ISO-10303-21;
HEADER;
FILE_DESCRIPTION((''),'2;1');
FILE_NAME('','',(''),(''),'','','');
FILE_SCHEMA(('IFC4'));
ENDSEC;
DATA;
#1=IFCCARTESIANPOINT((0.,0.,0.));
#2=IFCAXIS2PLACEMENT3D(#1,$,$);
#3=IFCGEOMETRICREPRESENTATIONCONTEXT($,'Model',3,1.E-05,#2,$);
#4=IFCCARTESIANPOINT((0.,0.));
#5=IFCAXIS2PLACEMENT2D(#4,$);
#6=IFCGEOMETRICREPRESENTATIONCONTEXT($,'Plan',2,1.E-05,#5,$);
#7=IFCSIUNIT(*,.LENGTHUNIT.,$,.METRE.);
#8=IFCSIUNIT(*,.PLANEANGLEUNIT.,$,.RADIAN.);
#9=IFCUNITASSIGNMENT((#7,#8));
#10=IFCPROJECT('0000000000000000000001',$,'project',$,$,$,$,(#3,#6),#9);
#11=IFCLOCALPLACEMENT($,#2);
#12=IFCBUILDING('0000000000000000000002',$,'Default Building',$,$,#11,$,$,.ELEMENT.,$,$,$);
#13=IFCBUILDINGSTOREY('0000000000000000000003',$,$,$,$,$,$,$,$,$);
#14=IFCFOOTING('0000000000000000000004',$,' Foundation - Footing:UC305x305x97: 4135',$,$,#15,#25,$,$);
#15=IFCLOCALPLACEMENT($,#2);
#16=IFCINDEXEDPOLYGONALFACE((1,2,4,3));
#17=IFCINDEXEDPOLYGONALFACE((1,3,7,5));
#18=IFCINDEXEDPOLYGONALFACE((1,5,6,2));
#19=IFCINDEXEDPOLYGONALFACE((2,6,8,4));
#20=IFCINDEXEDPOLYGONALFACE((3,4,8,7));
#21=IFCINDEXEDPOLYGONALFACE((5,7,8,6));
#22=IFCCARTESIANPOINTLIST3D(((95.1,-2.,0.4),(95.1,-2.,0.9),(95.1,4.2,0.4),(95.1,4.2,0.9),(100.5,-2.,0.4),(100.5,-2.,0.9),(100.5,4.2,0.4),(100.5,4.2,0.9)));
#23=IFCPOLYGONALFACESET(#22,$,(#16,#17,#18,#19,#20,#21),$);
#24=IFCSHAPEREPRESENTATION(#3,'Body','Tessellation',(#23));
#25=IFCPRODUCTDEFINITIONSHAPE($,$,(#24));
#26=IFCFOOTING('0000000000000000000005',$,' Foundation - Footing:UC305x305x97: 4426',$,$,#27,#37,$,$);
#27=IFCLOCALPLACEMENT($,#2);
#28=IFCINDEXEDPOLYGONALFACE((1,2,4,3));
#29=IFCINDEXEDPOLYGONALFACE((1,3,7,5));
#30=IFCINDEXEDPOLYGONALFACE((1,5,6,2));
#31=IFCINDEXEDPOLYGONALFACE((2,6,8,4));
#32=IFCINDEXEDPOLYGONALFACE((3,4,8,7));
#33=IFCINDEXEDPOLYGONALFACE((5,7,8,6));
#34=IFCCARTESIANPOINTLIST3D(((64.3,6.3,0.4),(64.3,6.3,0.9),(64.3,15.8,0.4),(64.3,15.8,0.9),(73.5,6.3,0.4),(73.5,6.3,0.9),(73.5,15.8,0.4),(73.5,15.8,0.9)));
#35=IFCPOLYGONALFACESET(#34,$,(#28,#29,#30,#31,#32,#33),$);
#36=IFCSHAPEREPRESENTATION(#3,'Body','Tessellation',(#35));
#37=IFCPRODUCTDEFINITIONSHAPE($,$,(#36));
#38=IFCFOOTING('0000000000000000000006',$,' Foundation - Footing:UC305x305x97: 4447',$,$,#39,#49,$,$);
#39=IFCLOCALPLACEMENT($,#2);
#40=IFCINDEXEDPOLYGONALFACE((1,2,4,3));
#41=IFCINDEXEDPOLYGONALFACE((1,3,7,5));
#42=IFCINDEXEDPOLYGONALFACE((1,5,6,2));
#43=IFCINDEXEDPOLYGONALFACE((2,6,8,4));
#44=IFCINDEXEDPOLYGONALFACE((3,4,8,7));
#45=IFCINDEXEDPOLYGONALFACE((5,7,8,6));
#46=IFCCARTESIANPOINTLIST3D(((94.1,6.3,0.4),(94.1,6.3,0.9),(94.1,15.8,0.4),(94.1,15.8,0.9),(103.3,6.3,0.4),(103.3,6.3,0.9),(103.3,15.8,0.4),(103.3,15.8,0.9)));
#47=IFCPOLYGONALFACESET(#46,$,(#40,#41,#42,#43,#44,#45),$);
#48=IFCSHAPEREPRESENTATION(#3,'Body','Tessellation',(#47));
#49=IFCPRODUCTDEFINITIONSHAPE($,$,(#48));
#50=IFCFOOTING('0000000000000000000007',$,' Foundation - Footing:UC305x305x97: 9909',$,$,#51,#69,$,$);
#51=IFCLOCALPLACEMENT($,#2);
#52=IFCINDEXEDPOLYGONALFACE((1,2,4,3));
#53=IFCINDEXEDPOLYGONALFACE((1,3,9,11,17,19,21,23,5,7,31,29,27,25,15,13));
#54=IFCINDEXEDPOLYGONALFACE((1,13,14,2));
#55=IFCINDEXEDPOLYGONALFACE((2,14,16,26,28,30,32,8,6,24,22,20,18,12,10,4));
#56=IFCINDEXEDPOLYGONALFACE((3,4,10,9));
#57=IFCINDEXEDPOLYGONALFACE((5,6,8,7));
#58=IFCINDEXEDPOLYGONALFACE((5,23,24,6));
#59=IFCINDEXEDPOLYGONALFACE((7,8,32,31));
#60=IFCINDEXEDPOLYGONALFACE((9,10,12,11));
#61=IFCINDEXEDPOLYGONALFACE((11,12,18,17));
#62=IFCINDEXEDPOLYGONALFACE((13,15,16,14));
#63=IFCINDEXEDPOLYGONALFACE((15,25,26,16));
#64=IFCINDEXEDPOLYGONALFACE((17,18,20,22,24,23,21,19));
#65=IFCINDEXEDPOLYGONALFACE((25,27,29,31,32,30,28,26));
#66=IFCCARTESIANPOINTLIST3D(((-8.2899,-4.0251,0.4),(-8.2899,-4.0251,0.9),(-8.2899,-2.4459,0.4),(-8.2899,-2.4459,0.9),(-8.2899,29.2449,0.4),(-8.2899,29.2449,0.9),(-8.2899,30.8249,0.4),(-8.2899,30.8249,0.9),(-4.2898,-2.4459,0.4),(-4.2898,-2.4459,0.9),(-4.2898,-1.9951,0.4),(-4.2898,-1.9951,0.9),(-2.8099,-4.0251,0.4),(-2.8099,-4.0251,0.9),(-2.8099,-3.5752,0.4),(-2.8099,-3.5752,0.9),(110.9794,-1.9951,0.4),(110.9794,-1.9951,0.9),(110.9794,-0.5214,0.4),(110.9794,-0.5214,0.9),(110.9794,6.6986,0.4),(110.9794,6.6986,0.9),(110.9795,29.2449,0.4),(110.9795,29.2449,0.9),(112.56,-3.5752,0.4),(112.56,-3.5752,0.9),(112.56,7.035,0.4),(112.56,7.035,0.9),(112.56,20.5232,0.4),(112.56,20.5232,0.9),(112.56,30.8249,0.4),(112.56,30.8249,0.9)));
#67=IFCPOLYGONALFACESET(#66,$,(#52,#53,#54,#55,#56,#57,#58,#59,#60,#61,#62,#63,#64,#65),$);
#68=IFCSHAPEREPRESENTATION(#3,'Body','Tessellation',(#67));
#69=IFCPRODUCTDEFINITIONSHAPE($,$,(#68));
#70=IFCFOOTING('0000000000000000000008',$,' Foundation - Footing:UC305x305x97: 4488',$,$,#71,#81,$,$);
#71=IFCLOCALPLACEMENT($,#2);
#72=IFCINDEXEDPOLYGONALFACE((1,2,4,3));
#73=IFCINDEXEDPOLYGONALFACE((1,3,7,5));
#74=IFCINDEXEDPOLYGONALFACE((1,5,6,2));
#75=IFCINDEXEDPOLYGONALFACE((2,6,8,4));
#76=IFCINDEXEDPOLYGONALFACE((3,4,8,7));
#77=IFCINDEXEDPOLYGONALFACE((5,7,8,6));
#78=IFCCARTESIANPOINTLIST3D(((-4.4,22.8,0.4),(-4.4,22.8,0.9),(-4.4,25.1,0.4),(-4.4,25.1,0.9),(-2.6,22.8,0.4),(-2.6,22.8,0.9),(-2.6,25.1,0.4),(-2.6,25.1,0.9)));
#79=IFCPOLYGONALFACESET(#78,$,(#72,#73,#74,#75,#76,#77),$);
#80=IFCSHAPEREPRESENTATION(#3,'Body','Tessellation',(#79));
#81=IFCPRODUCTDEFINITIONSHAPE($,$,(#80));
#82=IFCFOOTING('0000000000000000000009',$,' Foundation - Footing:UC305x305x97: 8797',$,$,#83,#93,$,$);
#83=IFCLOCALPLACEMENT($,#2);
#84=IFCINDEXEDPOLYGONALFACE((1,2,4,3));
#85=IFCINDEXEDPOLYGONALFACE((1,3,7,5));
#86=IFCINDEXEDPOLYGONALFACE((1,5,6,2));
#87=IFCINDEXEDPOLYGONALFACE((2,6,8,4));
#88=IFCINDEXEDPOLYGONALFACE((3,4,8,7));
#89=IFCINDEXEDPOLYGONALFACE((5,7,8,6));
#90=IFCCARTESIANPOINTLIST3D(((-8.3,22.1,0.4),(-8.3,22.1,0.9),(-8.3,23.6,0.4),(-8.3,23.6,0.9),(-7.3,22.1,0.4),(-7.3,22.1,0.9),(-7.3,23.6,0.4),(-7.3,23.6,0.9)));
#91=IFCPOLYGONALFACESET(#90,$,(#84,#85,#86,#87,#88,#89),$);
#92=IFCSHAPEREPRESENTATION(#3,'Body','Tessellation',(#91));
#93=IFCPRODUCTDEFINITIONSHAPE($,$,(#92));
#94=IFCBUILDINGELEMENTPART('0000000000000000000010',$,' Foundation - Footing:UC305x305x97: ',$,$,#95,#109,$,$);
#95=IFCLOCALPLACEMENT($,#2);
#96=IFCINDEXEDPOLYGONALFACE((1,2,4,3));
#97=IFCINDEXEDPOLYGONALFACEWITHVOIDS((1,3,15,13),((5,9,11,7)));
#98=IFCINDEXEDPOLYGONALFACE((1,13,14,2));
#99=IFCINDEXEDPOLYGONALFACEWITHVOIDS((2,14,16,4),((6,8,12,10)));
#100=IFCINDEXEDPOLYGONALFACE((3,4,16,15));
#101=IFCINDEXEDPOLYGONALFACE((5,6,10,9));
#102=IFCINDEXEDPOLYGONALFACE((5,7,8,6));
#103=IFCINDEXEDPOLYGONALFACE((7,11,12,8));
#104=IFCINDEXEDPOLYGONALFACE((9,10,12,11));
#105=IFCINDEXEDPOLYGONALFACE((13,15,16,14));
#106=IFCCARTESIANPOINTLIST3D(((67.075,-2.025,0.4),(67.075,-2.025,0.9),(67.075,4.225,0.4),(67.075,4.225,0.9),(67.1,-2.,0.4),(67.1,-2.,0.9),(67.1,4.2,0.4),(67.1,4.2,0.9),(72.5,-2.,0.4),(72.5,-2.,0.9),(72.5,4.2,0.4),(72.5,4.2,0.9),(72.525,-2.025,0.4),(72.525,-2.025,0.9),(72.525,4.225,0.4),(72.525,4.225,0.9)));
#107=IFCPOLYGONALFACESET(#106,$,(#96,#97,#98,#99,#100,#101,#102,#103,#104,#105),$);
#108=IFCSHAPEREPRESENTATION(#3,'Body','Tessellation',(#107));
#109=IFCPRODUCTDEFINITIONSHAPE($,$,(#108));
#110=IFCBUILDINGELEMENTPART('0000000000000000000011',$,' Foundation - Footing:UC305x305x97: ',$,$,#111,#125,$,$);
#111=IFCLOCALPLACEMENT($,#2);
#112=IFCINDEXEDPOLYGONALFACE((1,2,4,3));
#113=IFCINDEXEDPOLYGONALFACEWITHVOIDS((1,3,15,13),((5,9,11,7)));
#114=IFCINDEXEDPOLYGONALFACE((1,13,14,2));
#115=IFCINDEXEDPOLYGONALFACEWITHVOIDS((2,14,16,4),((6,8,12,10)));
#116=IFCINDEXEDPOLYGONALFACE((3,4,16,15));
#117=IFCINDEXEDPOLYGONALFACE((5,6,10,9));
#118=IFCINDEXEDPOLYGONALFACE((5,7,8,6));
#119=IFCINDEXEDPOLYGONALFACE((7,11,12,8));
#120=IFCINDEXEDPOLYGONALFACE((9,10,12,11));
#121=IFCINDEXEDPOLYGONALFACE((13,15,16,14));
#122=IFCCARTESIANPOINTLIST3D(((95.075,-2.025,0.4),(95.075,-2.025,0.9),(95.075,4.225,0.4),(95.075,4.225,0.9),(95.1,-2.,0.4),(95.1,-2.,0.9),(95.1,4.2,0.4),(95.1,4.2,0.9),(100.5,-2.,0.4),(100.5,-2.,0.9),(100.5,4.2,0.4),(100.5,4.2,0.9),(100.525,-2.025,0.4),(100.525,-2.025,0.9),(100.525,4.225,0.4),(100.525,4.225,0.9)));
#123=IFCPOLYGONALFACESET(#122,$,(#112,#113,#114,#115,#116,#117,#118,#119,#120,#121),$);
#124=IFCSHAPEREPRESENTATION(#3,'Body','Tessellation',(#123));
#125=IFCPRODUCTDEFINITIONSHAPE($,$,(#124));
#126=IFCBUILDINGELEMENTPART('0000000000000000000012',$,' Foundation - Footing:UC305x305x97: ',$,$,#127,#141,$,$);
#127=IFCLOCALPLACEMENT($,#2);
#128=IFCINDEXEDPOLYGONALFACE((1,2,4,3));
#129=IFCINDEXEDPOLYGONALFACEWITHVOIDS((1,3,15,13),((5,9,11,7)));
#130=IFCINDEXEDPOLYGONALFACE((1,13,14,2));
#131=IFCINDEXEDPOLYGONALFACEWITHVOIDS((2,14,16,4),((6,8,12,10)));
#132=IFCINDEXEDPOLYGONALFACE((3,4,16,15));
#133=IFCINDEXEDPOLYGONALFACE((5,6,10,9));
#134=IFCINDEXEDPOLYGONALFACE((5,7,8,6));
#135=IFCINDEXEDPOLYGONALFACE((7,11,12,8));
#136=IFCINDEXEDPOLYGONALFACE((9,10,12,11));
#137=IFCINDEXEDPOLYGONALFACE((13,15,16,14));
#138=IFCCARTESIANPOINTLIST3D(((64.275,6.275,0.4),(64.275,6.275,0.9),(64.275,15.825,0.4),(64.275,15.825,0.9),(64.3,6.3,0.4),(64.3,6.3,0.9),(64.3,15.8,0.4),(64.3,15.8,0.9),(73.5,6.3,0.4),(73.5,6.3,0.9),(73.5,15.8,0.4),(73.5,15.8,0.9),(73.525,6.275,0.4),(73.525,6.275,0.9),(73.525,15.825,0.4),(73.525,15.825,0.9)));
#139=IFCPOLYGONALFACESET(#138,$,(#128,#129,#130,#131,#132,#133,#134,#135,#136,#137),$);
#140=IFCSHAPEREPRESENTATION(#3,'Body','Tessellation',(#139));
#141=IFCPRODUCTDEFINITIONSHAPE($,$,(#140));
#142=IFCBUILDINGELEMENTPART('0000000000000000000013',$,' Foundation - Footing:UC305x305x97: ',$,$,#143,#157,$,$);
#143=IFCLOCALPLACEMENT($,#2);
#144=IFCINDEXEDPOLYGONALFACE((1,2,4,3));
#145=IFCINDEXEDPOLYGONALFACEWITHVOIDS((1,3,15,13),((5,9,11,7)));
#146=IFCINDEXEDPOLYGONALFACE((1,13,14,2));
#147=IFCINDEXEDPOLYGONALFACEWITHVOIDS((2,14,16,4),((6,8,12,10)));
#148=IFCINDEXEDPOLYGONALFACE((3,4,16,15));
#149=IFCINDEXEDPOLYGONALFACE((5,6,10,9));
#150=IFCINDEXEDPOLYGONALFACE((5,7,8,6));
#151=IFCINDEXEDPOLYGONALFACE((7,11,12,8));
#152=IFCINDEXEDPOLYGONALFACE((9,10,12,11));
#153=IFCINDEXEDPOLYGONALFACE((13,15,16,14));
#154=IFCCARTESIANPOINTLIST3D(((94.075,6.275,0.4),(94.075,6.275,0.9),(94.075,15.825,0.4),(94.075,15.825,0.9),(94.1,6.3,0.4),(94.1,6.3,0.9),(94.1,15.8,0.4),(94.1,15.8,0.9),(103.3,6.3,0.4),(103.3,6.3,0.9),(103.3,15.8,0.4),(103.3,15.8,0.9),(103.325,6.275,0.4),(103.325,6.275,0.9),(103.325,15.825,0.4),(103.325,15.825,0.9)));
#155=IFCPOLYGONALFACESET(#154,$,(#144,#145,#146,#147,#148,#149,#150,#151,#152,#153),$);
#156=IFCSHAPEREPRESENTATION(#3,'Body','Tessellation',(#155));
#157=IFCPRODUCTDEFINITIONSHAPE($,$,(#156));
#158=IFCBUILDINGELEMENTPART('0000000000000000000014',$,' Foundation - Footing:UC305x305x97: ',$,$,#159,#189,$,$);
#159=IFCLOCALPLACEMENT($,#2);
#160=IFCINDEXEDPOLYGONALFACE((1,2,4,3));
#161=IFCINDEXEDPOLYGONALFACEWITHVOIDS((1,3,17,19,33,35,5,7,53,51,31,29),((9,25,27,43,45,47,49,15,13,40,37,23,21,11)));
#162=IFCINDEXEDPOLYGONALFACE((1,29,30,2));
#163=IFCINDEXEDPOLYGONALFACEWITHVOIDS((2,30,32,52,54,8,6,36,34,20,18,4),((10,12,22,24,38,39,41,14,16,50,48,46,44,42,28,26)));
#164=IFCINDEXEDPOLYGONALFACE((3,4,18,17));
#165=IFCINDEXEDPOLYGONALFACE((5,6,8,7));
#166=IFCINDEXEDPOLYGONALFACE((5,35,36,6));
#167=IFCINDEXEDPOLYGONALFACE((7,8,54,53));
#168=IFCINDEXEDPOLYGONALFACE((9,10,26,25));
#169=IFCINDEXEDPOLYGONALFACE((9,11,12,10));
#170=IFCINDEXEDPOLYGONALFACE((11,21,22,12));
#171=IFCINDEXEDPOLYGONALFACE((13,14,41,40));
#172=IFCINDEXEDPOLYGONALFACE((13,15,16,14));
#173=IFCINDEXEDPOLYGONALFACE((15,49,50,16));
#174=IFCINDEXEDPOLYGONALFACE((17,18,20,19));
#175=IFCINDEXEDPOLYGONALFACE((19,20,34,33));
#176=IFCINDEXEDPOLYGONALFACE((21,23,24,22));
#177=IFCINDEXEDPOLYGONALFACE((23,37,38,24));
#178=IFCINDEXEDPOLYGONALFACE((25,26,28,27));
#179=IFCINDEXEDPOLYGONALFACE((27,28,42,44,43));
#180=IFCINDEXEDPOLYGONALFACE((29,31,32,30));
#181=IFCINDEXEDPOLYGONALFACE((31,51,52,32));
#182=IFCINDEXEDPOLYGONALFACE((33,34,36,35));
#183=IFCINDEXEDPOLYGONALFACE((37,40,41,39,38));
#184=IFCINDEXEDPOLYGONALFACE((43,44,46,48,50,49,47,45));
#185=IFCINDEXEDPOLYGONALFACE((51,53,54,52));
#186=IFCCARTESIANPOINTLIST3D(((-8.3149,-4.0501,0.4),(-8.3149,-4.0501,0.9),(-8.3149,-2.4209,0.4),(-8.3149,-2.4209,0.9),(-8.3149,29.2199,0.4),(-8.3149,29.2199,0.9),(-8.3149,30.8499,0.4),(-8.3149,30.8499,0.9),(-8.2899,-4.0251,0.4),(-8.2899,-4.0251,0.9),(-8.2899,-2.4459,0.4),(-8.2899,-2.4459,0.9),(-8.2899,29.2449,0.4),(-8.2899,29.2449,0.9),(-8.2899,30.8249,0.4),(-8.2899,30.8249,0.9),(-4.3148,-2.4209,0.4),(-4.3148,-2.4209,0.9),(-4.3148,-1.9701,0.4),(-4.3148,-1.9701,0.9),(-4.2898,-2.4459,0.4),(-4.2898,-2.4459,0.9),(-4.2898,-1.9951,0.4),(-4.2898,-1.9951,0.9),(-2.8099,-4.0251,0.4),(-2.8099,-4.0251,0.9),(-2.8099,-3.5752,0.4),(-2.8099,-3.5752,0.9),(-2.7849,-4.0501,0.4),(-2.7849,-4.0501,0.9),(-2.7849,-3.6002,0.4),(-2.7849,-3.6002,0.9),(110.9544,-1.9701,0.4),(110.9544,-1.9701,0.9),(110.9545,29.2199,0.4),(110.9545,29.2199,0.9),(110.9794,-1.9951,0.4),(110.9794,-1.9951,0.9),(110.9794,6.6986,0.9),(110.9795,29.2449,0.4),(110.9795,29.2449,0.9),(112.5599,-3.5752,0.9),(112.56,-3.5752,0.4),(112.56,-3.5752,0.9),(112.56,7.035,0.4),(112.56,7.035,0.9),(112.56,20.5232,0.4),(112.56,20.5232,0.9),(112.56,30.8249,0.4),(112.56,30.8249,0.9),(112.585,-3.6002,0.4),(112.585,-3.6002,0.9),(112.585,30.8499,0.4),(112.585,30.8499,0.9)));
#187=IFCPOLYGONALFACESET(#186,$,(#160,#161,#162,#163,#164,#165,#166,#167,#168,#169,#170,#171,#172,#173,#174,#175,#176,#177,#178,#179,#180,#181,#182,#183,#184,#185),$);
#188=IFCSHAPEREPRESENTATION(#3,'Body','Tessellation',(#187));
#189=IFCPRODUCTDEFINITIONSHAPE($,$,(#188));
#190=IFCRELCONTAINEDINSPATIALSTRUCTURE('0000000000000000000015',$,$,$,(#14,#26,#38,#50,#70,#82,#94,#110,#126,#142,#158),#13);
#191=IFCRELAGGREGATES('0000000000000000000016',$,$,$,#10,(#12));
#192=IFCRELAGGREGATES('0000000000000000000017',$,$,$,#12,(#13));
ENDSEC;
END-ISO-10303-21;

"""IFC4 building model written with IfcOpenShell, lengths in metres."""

from ifc_helpers import new_model, si_unit, origin, origin_2d, place, context, project, spatial, polyline, outline, extrude, element, save


model = new_model("IFC4")

# Units and contexts
model_context = context("Model", 3, precision=1e-05, world=origin())
plan_context = context("Plan", 2, precision=1e-05, world=origin_2d())
ifc_project = project(units=[si_unit("LENGTHUNIT", "METRE"), si_unit("PLANEANGLEUNIT", "RADIAN")], contexts=[model_context, plan_context])

# Building, storey
building_placement = place(None, origin())
building = spatial("IfcBuilding", under=ifc_project, at=building_placement, Name="Default Building", CompositionType="ELEMENT")
storey = spatial("IfcBuildingStorey", under=building)

# Footings
element("IfcFooting", 1, inside=storey, Name=" Foundation - Footing:UC305x305x97: 4135", context=model_context, shape_type="SweptSolid", body=[
    extrude(outline(polyline([(100.5, -2.0, 0.4), (100.5, 4.2, 0.4), (95.1, 4.2, 0.4), (95.1, -2.0, 0.4), (100.5, -2.0, 0.4)])), None, (0.0, 0.0, 1.0), 0.5),
])
element("IfcFooting", 2, inside=storey, Name=" Foundation - Footing:UC305x305x97: 4426", context=model_context, shape_type="SweptSolid", body=[
    extrude(outline(polyline([(64.3, 15.8, 0.4), (73.5, 15.8, 0.4), (73.5, 6.3, 0.4), (64.3, 6.3, 0.4), (64.3, 15.8, 0.4)])), None, (0.0, 0.0, 1.0), 0.5),
])
element("IfcFooting", 3, inside=storey, Name=" Foundation - Footing:UC305x305x97: 4447", context=model_context, shape_type="SweptSolid", body=[
    extrude(outline(polyline([(94.1, 15.8, 0.4), (103.3, 15.8, 0.4), (103.3, 6.3, 0.4), (94.1, 6.3, 0.4), (94.1, 15.8, 0.4)])), None, (0.0, 0.0, 1.0), 0.5),
])
element("IfcFooting", 4, inside=storey, Name=" Foundation - Footing:UC305x305x97: 9909", context=model_context, shape_type="SweptSolid", body=[
    extrude(outline(polyline([(-8.2899, 30.8249, 0.4), (112.56, 30.8249, 0.4), (112.56, 20.5232, 0.4), (112.56, 7.035, 0.4), (112.56, -3.5752, 0.4), (-2.8099, -3.5752, 0.4), (-2.8099, -4.0251, 0.4), (-8.2899, -4.0251, 0.4), (-8.2899, -2.4459, 0.4), (-4.2898, -2.4459, 0.4), (-4.2898, -1.9951, 0.4), (110.9794, -1.9951, 0.4), (110.9794, -0.5214, 0.4), (110.9794, 6.6986, 0.4), (110.9795, 29.2449, 0.4), (-8.2899, 29.2449, 0.4), (-8.2899, 30.8249, 0.4)])), None, (0.0, 0.0, 1.0), 0.5),
])
element("IfcFooting", 5, inside=storey, Name=" Foundation - Footing:UC305x305x97: 4488", context=model_context, shape_type="SweptSolid", body=[
    extrude(outline(polyline([(-4.4, 25.1, 0.4), (-2.6, 25.1, 0.4), (-2.6, 22.8, 0.4), (-4.4, 22.8, 0.4), (-4.4, 25.1, 0.4)])), None, (0.0, 0.0, 1.0), 0.5),
])
element("IfcFooting", 6, inside=storey, Name=" Foundation - Footing:UC305x305x97: 8797", context=model_context, shape_type="SweptSolid", body=[
    extrude(outline(polyline([(-7.3, 23.6, 0.4), (-8.3, 23.6, 0.4), (-8.3, 22.1, 0.4), (-7.3, 22.1, 0.4), (-7.3, 23.6, 0.4)])), None, (0.0, 0.0, 1.0), 0.5),
])

# Building element parts, openings
building_element_part_1 = element("IfcBuildingElementPart", 7, inside=storey, Name=" Foundation - Footing:UC305x305x97: ", context=model_context, shape_type="SweptSolid", body=[
    extrude(outline(polyline([(72.525, -2.025, 0.4), (72.525, 4.225, 0.4), (67.075, 4.225, 0.4), (67.075, -2.025, 0.4), (72.525, -2.025, 0.4)])), None, (0.0, 0.0, 1.0), 0.5),
])
element("IfcOpeningElement", 8, inside=storey, cuts=building_element_part_1, context=model_context, shape_type="SweptSolid", body=[
    extrude(outline(polyline([(72.5, -2.0, 0.4), (72.5, 4.2, 0.4), (67.1, 4.2, 0.4), (67.1, -2.0, 0.4), (72.5, -2.0, 0.4)])), None, (0.0, 0.0, 1.0), 0.5),
])
building_element_part_2 = element("IfcBuildingElementPart", 9, inside=storey, Name=" Foundation - Footing:UC305x305x97: ", context=model_context, shape_type="SweptSolid", body=[
    extrude(outline(polyline([(100.525, -2.025, 0.4), (100.525, 4.225, 0.4), (95.075, 4.225, 0.4), (95.075, -2.025, 0.4), (100.525, -2.025, 0.4)])), None, (0.0, 0.0, 1.0), 0.5),
])
element("IfcOpeningElement", 10, inside=storey, cuts=building_element_part_2, context=model_context, shape_type="SweptSolid", body=[
    extrude(outline(polyline([(100.5, -2.0, 0.4), (100.5, 4.2, 0.4), (95.1, 4.2, 0.4), (95.1, -2.0, 0.4), (100.5, -2.0, 0.4)])), None, (0.0, 0.0, 1.0), 0.5),
])
building_element_part_3 = element("IfcBuildingElementPart", 11, inside=storey, Name=" Foundation - Footing:UC305x305x97: ", context=model_context, shape_type="SweptSolid", body=[
    extrude(outline(polyline([(64.275, 15.825, 0.4), (73.525, 15.825, 0.4), (73.525, 6.275, 0.4), (64.275, 6.275, 0.4), (64.275, 15.825, 0.4)])), None, (0.0, 0.0, 1.0), 0.5),
])
element("IfcOpeningElement", 12, inside=storey, cuts=building_element_part_3, context=model_context, shape_type="SweptSolid", body=[
    extrude(outline(polyline([(64.3, 15.8, 0.4), (73.5, 15.8, 0.4), (73.5, 6.3, 0.4), (64.3, 6.3, 0.4), (64.3, 15.8, 0.4)])), None, (0.0, 0.0, 1.0), 0.5),
])
building_element_part_4 = element("IfcBuildingElementPart", 13, inside=storey, Name=" Foundation - Footing:UC305x305x97: ", context=model_context, shape_type="SweptSolid", body=[
    extrude(outline(polyline([(94.075, 15.825, 0.4), (103.325, 15.825, 0.4), (103.325, 6.275, 0.4), (94.075, 6.275, 0.4), (94.075, 15.825, 0.4)])), None, (0.0, 0.0, 1.0), 0.5),
])
element("IfcOpeningElement", 14, inside=storey, cuts=building_element_part_4, context=model_context, shape_type="SweptSolid", body=[
    extrude(outline(polyline([(94.1, 15.8, 0.4), (103.3, 15.8, 0.4), (103.3, 6.3, 0.4), (94.1, 6.3, 0.4), (94.1, 15.8, 0.4)])), None, (0.0, 0.0, 1.0), 0.5),
])
building_element_part_5 = element("IfcBuildingElementPart", 15, inside=storey, Name=" Foundation - Footing:UC305x305x97: ", context=model_context, shape_type="SweptSolid", body=[
    extrude(outline(polyline([(-8.3149, 30.8499, 0.4), (112.585, 30.8499, 0.4), (112.585, 20.5232, 0.4), (112.585, 7.035, 0.4), (112.585, -3.6002, 0.4), (-2.7849, -3.6002, 0.4), (-2.7849, -4.0501, 0.4), (-8.3149, -4.0501, 0.4), (-8.3149, -2.4209, 0.4), (-4.3148, -2.4209, 0.4), (-4.3148, -1.9701, 0.4), (110.9544, -1.9701, 0.4), (110.9544, -0.5214, 0.4), (110.9544, 6.6986, 0.4), (110.9545, 29.2199, 0.4), (-8.3149, 29.2199, 0.4), (-8.3149, 30.8499, 0.4)])), None, (0.0, 0.0, 1.0), 0.5),
])
element("IfcOpeningElement", 16, inside=storey, cuts=building_element_part_5, context=model_context, shape_type="SweptSolid", body=[
    extrude(outline(polyline([(-8.2899, 30.8249, 0.4), (112.56, 30.8249, 0.4), (112.56, 20.5232, 0.4), (112.56, 7.035, 0.4), (112.56, -3.5752, 0.4), (-2.8099, -3.5752, 0.4), (-2.8099, -4.0251, 0.4), (-8.2899, -4.0251, 0.4), (-8.2899, -2.4459, 0.4), (-4.2898, -2.4459, 0.4), (-4.2898, -1.9951, 0.4), (110.9794, -1.9951, 0.4), (110.9794, -0.5214, 0.4), (110.9794, 6.6986, 0.4), (110.9795, 29.2449, 0.4), (-8.2899, 29.2449, 0.4), (-8.2899, 30.8249, 0.4)])), None, (0.0, 0.0, 1.0), 0.5),
])

save(model, "model.ifc")
